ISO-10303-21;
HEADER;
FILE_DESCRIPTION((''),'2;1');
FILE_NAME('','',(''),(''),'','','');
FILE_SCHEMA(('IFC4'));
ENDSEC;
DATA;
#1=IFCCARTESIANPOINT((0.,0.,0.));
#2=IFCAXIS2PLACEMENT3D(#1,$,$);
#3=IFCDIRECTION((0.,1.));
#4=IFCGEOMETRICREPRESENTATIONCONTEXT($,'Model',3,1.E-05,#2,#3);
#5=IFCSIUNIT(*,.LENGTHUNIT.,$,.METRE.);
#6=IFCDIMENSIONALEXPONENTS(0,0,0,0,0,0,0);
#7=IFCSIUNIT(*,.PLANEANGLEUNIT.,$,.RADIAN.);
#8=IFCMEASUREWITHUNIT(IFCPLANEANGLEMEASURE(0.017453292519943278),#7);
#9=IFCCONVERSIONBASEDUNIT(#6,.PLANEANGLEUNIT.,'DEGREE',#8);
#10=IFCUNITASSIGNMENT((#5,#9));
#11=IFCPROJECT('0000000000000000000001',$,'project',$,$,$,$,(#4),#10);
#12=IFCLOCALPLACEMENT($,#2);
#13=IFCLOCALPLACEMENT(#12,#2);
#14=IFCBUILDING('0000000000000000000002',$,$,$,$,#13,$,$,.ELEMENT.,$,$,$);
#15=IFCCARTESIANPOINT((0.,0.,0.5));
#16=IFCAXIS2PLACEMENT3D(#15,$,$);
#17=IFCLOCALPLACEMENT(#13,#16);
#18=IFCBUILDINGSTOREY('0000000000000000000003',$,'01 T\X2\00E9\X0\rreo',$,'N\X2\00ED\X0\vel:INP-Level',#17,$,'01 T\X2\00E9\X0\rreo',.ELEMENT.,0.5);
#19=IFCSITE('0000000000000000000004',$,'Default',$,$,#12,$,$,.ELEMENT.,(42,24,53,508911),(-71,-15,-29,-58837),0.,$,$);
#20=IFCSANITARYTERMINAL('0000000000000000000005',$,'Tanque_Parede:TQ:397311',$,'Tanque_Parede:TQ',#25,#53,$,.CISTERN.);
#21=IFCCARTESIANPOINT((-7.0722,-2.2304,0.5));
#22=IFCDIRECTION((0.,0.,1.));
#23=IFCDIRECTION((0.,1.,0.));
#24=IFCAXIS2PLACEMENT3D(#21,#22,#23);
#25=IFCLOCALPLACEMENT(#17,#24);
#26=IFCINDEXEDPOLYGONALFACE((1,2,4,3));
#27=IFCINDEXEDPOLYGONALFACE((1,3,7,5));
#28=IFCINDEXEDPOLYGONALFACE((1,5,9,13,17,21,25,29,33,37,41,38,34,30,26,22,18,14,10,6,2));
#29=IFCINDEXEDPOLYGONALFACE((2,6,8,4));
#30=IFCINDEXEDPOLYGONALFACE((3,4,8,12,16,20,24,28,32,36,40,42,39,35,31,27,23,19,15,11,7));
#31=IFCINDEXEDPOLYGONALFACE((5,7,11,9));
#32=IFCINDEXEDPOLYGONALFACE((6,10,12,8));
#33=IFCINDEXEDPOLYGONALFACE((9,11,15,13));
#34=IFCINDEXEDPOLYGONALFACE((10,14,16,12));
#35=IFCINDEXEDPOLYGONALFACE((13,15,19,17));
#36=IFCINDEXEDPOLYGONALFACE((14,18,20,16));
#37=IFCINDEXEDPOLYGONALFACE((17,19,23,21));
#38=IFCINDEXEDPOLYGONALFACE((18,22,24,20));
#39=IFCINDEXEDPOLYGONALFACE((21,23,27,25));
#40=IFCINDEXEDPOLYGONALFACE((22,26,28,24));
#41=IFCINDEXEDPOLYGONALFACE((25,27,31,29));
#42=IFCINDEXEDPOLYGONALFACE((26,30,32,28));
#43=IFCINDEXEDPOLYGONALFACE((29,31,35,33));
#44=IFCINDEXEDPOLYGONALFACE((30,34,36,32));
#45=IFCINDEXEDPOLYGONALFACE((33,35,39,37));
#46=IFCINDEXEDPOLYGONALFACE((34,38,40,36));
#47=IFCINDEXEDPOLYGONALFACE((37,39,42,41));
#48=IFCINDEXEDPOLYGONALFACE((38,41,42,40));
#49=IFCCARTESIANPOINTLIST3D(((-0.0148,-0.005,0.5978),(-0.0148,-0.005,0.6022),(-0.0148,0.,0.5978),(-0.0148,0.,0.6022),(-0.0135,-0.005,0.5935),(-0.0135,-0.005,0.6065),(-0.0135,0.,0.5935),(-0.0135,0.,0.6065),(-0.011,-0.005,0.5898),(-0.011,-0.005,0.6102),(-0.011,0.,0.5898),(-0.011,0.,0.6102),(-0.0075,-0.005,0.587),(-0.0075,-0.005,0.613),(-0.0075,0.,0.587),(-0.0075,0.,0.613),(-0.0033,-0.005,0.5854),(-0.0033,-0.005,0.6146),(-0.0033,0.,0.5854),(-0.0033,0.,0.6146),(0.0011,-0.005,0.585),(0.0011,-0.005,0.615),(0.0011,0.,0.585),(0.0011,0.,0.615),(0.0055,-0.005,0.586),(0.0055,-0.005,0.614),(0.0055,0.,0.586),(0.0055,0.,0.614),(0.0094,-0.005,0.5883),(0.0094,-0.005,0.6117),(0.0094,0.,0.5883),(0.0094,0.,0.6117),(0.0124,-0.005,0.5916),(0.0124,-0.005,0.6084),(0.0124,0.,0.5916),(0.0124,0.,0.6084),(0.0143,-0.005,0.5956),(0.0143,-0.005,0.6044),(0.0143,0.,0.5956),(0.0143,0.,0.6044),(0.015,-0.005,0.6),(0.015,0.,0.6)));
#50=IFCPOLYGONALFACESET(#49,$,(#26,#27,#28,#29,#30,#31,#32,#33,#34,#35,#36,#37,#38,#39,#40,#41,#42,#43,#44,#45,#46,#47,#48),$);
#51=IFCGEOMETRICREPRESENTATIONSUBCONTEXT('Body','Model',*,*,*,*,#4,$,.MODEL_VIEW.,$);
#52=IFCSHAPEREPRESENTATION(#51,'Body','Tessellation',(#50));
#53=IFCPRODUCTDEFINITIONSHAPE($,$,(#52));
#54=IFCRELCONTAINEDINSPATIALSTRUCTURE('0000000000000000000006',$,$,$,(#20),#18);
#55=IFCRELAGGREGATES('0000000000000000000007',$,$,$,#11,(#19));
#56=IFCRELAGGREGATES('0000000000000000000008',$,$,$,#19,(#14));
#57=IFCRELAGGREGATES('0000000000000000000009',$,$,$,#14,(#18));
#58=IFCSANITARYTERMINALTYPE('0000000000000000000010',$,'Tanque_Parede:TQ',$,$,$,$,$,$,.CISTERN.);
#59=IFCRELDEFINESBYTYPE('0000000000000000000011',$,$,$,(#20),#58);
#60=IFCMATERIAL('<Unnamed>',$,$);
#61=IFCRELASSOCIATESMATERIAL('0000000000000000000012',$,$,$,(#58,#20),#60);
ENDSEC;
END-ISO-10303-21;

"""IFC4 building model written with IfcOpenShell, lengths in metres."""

from ifc_helpers import new_model, entity, si_unit, converted_unit, direction, frame, frame_2d, origin, place, context, subcontext, project, spatial, circle, extrude, source, transform, mapped, material, type_object, type_shapes, element, save


model = new_model("IFC4")

# Units and contexts
model_context = context("Model", 3, precision=1e-05, world=origin(), true_north=direction((0.0, 1.0)))
body_context = subcontext(model_context, "Body", "Model", "MODEL_VIEW")
ifc_project = project(units=[si_unit("LENGTHUNIT", "METRE"), converted_unit("PLANEANGLEUNIT", "DEGREE", entity("IfcPlaneAngleMeasure", 0.017453292519943278), si_unit("PLANEANGLEUNIT", "RADIAN"), dimensions=[0, 0, 0, 0, 0, 0, 0])], contexts=[model_context])

# Site, building, storey
site_placement = place(None, origin())
site = spatial("IfcSite", under=ifc_project, at=site_placement, Name="Default", CompositionType="ELEMENT", RefLatitude=(42, 24, 53, 508911), RefLongitude=(-71, -15, -29, -58837), RefElevation=0.0)
building_placement = place(site_placement, origin())
building = spatial("IfcBuilding", under=site, at=building_placement, CompositionType="ELEMENT")
storey_placement = place(building_placement, frame((0.0, 0.0, 0.5)))
storey = spatial("IfcBuildingStorey", under=building, at=storey_placement, Name="01 Térreo", ObjectType="Nível:INP-Level", LongName="01 Térreo", CompositionType="ELEMENT", Elevation=0.5)

# Sanitary terminal
ifc_material = material(Name="<Unnamed>")
sanitary_terminal_type_1 = type_object("IfcSanitaryTerminalType", Name="Tanque_Parede:TQ", PredefinedType="CISTERN", material=ifc_material)
shared_shape_1 = source(origin(), body_context, "Body", "SweptSolid", [
    extrude(circle(Radius=0.015, at=frame_2d((0.0, 0.0), x_axis=(1.0, 0.0))), frame((0.0, -0.005, 0.6), z_axis=(0.0, 1.0, 0.0), x_axis=(1.0, 0.0, 0.0)), (0.0, 0.0, 1.0), 0.005),
])
type_shapes(sanitary_terminal_type_1, [shared_shape_1])
sanitary_terminal_1_placement = place(storey_placement, frame((-7.0722, -2.2304, 0.5), z_axis=(0.0, 0.0, 1.0), x_axis=(0.0, 1.0, 0.0)))
element("IfcSanitaryTerminal", 1, at=sanitary_terminal_1_placement, inside=storey, type_object=sanitary_terminal_type_1, material=ifc_material, Name="Tanque_Parede:TQ:397311", ObjectType="Tanque_Parede:TQ", PredefinedType="CISTERN", context=body_context, shape_type="MappedRepresentation", body=[
    mapped(shared_shape_1, transform((0.0, 0.0, 0.0), scale=1.0)),
])

save(model, "model.ifc")
